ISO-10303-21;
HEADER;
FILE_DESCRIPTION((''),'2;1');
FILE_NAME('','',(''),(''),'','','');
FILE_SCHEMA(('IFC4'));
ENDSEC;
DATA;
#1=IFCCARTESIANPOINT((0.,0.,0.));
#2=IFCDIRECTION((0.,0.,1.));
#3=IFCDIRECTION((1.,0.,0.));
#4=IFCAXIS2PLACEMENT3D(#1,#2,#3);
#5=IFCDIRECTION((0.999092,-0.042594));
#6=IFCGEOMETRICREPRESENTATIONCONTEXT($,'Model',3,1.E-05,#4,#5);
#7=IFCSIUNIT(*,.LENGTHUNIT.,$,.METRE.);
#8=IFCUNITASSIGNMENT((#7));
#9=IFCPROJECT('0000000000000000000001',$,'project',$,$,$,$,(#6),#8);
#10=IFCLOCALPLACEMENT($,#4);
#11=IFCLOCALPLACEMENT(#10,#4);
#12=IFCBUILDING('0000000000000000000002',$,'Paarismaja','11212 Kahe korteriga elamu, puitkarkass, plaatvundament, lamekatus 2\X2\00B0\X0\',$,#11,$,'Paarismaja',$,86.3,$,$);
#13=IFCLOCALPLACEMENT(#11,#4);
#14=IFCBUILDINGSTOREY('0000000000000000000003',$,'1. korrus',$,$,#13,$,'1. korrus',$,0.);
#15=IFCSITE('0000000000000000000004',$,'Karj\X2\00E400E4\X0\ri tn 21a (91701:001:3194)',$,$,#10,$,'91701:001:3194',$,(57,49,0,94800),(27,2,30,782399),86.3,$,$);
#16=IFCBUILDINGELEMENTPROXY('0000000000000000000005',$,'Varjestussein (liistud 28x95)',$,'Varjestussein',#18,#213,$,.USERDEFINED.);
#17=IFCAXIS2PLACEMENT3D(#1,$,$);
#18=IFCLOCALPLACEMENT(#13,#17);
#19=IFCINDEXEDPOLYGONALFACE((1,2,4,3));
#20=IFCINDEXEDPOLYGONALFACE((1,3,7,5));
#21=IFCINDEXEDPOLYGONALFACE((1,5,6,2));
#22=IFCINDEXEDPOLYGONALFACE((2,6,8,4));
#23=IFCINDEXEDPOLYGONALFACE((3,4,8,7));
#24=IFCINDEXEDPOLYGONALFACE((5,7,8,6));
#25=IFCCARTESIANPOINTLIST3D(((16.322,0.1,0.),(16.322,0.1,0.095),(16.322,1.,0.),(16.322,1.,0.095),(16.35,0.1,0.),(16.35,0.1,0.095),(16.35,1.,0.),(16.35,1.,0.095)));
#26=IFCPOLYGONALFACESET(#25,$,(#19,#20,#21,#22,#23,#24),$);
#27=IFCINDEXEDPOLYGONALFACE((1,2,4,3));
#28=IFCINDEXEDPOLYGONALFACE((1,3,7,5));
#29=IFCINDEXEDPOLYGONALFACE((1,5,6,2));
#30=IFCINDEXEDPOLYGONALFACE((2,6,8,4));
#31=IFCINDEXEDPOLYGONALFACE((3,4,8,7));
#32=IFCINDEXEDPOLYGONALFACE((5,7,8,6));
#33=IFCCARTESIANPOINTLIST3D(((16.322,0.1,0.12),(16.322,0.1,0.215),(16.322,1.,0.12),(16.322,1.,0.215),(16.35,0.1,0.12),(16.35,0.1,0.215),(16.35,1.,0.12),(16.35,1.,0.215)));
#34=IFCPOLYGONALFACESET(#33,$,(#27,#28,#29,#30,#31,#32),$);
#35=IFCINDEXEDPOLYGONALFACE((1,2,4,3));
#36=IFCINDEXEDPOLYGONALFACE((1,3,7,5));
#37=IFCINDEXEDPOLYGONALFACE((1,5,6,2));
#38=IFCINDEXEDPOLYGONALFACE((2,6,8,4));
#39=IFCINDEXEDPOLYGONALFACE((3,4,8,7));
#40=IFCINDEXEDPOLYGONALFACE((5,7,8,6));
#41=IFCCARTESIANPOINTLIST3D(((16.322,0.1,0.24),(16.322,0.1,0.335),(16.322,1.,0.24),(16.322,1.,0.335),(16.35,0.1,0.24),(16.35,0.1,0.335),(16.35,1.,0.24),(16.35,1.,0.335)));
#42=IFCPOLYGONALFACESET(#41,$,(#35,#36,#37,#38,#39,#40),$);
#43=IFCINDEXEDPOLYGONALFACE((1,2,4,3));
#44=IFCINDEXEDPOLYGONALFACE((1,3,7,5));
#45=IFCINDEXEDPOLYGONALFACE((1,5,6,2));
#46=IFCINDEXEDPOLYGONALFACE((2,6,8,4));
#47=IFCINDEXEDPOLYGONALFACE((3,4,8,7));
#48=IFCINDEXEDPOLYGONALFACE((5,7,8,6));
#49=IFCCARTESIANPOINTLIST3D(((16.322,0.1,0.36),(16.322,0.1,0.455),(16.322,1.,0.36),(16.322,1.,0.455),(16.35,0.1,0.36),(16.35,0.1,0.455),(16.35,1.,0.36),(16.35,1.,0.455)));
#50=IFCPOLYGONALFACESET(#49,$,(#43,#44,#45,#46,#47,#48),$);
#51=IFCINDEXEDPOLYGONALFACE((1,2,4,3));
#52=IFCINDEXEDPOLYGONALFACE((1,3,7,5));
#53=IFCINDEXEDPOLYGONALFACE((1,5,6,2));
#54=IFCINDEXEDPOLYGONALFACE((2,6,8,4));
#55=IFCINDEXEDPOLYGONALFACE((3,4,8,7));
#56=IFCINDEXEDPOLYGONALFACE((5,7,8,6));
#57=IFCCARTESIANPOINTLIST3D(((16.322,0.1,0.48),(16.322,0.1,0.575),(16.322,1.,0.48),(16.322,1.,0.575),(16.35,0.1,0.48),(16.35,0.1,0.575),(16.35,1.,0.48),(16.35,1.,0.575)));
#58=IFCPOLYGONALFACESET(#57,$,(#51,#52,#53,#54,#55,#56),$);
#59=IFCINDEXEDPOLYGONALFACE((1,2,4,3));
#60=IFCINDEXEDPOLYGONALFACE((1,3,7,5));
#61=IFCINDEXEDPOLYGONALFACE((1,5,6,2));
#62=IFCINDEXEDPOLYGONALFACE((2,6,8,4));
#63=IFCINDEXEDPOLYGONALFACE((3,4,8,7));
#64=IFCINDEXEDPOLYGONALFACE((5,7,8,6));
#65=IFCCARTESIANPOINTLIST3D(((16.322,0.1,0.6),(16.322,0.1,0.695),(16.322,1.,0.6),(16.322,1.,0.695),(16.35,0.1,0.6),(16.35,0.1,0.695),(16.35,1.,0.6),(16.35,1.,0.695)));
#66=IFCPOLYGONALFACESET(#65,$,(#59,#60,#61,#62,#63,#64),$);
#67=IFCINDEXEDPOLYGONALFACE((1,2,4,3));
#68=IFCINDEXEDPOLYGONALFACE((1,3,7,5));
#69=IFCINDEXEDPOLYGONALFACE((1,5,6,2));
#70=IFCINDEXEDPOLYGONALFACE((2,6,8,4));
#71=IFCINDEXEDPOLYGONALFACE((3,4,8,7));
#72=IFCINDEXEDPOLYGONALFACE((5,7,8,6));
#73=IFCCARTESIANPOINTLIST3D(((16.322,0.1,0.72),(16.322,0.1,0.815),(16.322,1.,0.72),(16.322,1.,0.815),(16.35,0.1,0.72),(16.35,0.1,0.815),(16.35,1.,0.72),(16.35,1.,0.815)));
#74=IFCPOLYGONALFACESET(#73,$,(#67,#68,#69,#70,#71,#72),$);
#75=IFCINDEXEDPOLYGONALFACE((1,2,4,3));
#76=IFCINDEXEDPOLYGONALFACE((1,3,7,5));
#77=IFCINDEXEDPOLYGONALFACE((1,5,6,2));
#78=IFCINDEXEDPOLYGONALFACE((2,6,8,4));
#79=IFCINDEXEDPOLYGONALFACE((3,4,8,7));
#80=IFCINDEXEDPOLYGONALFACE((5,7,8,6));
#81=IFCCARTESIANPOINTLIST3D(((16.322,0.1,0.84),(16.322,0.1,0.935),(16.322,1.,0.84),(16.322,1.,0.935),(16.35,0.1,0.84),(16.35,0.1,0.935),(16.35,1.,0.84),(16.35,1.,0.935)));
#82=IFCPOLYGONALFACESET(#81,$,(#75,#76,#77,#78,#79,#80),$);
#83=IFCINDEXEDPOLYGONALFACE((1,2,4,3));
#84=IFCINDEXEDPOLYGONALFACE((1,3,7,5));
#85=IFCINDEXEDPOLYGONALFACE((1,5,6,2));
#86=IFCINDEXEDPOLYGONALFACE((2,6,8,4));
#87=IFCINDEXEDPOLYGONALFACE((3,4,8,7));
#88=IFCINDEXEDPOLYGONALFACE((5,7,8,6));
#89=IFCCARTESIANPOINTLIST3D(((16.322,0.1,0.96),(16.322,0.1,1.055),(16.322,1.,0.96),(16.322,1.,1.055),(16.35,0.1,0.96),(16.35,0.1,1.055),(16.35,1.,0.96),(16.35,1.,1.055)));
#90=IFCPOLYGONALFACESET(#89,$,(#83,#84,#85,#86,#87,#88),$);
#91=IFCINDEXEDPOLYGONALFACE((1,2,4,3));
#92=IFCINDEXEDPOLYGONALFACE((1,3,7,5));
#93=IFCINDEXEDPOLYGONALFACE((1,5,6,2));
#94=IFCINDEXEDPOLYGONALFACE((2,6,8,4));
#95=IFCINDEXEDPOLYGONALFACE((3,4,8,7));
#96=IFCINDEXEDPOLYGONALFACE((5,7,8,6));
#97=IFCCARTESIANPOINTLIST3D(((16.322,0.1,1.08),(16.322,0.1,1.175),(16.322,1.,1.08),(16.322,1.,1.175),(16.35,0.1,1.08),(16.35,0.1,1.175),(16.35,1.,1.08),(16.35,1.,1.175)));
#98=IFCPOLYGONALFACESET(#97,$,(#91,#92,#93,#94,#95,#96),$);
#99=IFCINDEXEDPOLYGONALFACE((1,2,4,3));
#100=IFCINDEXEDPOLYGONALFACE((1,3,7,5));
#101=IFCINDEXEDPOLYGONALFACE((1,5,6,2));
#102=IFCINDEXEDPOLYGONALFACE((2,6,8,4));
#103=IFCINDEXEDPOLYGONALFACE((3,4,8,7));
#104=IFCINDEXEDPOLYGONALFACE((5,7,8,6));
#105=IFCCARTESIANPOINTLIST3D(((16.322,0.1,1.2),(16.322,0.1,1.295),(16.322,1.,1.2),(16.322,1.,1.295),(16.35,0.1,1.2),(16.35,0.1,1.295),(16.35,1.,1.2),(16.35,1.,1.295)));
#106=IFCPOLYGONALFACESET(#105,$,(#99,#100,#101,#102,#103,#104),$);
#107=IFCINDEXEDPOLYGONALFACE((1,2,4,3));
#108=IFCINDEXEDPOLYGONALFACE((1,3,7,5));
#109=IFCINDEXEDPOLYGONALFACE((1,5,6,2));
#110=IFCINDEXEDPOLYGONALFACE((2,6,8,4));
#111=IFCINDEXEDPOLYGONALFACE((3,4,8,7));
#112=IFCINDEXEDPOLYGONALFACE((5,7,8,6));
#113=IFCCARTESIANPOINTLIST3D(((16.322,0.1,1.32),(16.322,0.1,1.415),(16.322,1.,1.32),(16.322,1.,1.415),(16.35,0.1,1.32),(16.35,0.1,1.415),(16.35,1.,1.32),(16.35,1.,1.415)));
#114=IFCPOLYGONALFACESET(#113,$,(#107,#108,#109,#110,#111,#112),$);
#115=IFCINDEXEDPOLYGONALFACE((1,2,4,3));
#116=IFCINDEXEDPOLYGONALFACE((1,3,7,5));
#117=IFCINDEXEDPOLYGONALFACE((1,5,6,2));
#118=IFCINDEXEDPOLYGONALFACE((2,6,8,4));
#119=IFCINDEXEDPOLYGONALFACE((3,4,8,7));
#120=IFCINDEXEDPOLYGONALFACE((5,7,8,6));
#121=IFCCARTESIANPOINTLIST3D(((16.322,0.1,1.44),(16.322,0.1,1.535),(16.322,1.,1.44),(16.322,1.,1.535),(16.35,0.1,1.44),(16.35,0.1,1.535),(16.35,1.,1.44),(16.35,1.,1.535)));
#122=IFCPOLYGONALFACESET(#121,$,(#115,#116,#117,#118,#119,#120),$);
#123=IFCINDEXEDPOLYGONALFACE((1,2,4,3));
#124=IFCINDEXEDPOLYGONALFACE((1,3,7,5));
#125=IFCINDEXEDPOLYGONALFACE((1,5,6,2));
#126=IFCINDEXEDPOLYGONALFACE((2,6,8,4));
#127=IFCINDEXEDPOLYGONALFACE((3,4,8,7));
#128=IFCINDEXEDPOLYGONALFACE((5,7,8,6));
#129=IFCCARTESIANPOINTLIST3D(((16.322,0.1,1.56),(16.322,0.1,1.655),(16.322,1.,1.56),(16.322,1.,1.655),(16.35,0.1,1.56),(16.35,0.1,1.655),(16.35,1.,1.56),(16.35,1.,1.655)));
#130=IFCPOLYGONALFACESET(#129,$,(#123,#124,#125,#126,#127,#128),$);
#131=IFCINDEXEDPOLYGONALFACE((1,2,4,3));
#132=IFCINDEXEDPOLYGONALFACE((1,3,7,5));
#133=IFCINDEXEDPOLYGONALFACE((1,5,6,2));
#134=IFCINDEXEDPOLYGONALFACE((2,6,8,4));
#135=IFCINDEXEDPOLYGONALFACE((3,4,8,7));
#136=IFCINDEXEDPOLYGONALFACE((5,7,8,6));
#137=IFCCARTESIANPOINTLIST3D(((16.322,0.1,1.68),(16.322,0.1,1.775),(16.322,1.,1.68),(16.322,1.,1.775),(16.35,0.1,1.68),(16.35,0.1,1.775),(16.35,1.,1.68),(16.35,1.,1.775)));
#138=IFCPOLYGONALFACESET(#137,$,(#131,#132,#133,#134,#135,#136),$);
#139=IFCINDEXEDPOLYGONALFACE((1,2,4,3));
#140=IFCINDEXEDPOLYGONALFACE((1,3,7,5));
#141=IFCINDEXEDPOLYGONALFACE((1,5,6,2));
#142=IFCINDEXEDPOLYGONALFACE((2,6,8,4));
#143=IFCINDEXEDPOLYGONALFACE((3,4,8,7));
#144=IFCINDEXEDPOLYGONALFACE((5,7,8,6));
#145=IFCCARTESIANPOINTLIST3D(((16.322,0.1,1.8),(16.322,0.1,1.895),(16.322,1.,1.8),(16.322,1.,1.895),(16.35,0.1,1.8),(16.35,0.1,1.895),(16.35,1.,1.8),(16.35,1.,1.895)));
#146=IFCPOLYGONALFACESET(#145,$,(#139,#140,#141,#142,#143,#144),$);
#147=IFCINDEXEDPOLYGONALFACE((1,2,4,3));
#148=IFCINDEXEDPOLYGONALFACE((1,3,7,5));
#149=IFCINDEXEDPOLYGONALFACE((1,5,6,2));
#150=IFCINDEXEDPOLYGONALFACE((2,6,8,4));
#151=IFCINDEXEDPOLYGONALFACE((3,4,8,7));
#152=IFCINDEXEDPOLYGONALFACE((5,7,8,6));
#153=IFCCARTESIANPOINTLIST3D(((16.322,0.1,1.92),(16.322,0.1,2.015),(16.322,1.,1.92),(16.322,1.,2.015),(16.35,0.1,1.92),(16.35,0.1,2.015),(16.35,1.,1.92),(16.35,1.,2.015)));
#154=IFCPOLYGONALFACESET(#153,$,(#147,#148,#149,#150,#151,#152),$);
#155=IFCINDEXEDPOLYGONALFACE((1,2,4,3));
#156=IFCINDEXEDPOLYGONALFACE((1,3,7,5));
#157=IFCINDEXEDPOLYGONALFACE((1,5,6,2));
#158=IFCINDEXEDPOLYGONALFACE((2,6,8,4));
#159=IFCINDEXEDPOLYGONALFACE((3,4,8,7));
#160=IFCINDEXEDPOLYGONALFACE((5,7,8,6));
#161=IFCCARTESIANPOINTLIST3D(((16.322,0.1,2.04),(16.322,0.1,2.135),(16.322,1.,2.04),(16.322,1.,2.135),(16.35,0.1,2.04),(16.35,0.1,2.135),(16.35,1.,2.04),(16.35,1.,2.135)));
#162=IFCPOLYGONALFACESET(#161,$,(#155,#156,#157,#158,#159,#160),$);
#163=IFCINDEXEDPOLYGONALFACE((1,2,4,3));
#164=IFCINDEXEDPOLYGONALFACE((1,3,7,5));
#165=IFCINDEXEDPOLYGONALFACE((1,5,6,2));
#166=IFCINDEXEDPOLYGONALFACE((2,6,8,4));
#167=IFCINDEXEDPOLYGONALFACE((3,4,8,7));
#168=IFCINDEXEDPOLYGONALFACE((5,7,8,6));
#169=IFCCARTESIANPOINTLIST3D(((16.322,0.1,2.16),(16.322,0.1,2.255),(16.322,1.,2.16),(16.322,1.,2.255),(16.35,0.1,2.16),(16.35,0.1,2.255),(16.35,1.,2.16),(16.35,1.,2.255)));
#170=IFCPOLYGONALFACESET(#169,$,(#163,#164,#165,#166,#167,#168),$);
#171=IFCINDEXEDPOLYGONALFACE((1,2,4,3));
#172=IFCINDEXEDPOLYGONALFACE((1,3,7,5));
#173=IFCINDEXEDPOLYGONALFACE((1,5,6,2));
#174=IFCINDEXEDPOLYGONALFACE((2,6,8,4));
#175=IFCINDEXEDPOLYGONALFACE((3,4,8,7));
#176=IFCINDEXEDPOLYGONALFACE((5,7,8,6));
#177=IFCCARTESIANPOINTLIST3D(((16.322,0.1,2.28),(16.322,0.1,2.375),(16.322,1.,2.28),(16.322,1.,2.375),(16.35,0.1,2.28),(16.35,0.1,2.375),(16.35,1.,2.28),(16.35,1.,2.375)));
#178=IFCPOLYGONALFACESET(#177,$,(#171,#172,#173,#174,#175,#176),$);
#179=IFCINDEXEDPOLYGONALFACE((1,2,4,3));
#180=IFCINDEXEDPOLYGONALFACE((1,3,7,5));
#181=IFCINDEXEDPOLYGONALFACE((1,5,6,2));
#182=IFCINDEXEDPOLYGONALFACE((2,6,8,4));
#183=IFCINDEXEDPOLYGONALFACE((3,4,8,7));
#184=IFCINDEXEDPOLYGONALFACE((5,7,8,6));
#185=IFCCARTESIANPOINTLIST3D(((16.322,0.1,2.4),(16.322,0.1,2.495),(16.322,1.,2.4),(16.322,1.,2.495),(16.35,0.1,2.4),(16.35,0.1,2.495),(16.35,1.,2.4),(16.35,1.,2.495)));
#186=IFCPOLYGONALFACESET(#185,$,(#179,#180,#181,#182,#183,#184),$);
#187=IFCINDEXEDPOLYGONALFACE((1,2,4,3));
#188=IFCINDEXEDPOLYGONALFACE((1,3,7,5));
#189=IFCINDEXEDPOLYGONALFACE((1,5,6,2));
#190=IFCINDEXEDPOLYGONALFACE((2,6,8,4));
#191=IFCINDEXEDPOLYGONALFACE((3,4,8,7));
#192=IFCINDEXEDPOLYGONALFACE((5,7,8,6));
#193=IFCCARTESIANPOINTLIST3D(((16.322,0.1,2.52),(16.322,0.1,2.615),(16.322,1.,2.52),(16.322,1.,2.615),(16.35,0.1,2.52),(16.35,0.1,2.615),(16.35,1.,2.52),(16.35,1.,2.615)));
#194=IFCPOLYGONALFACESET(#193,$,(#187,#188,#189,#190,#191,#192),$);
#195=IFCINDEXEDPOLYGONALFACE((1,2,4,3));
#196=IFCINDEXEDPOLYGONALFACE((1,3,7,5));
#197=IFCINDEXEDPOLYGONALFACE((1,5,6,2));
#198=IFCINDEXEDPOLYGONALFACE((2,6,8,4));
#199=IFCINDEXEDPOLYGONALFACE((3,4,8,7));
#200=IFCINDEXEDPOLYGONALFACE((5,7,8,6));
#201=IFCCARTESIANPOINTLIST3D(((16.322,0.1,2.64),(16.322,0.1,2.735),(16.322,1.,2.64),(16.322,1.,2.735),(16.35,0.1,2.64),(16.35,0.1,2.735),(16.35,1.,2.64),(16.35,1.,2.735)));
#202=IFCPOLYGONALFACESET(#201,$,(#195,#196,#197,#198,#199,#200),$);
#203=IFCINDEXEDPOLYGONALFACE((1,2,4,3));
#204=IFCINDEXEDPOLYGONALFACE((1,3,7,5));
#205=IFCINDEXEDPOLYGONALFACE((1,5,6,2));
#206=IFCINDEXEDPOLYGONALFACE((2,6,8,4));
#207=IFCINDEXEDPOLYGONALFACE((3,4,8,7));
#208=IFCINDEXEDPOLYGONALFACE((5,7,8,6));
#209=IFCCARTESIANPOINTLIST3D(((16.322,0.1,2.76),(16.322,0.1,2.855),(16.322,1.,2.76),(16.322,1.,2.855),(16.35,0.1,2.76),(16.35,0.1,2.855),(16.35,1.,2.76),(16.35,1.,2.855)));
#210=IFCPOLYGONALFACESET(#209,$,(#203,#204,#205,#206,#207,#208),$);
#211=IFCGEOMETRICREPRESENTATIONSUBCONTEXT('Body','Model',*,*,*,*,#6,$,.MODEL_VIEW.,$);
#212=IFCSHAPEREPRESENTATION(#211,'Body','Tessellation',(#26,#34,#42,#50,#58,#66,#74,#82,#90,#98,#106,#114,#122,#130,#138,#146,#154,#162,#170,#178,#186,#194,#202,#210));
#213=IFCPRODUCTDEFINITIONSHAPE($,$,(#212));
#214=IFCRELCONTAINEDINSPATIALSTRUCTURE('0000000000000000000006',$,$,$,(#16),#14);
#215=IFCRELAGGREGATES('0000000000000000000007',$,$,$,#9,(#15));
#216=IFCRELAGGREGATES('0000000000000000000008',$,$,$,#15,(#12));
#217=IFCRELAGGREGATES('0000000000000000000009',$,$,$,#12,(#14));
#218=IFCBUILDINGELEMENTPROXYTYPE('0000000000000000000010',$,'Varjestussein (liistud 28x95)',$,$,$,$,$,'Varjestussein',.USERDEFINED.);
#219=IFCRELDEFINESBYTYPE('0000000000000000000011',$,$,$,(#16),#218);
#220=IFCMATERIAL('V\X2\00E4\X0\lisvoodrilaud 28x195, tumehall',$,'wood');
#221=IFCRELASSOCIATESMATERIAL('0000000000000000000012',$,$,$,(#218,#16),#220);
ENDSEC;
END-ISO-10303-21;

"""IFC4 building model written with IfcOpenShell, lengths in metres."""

from ifc_helpers import new_model, si_unit, direction, frame, origin_with_axes, place, context, subcontext, project, spatial, indexed_curve, outline, extrude, material, type_object, element, save


model = new_model("IFC4")

# Units and contexts
model_context = context("Model", 3, precision=1e-05, world=origin_with_axes(), true_north=direction((0.999092, -0.042594)))
body_context = subcontext(model_context, "Body", "Model", "MODEL_VIEW")
ifc_project = project(units=[si_unit("LENGTHUNIT", "METRE")], contexts=[model_context])

# Site, building, storey
site_placement = place(None, origin_with_axes())
site = spatial("IfcSite", under=ifc_project, at=site_placement, Name="Karjääri tn 21a (91701:001:3194)", LongName="91701:001:3194", RefLatitude=(57, 49, 0, 94800), RefLongitude=(27, 2, 30, 782399), RefElevation=86.3)
building_placement = place(site_placement, origin_with_axes())
building = spatial("IfcBuilding", under=site, at=building_placement, Name="Paarismaja", Description="11212 Kahe korteriga elamu, puitkarkass, plaatvundament, lamekatus 2°", LongName="Paarismaja", ElevationOfRefHeight=86.3)
storey_placement = place(building_placement, origin_with_axes())
storey = spatial("IfcBuildingStorey", under=building, at=storey_placement, Name="1. korrus", LongName="1. korrus", Elevation=0.0)

# Building element proxy
ifc_material_1 = material(Name="Välisvoodrilaud 28x195, tumehall", Category="wood")
building_element_proxy_type_1 = type_object("IfcBuildingElementProxyType", Name="Varjestussein (liistud 28x95)", ElementType="Varjestussein", PredefinedType="USERDEFINED", material=ifc_material_1)
proxy_1_placement = place(storey_placement, origin_with_axes())
element("IfcBuildingElementProxy", 1, at=proxy_1_placement, inside=storey, type_object=building_element_proxy_type_1, material=ifc_material_1, Name="Varjestussein (liistud 28x95)", ObjectType="Varjestussein", PredefinedType="USERDEFINED", context=body_context, shape_type="SweptSolid", body=[
    extrude(outline(indexed_curve([(16.322, 0.1), (16.35, 0.1), (16.35, 1.0), (16.322, 1.0), (16.322, 0.1)], self_intersect=False)), origin_with_axes(), (0.0, 0.0, 1.0), 0.095),
    extrude(outline(indexed_curve([(16.322, 0.1), (16.35, 0.1), (16.35, 1.0), (16.322, 1.0), (16.322, 0.1)], self_intersect=False)), frame((0.0, 0.0, 0.12), z_axis=(0.0, 0.0, 1.0), x_axis=(1.0, 0.0, 0.0)), (0.0, 0.0, 1.0), 0.095),
    extrude(outline(indexed_curve([(16.322, 0.1), (16.35, 0.1), (16.35, 1.0), (16.322, 1.0), (16.322, 0.1)], self_intersect=False)), frame((0.0, 0.0, 0.24), z_axis=(0.0, 0.0, 1.0), x_axis=(1.0, 0.0, 0.0)), (0.0, 0.0, 1.0), 0.095),
    extrude(outline(indexed_curve([(16.322, 0.1), (16.35, 0.1), (16.35, 1.0), (16.322, 1.0), (16.322, 0.1)], self_intersect=False)), frame((0.0, 0.0, 0.36), z_axis=(0.0, 0.0, 1.0), x_axis=(1.0, 0.0, 0.0)), (0.0, 0.0, 1.0), 0.095),
    extrude(outline(indexed_curve([(16.322, 0.1), (16.35, 0.1), (16.35, 1.0), (16.322, 1.0), (16.322, 0.1)], self_intersect=False)), frame((0.0, 0.0, 0.48), z_axis=(0.0, 0.0, 1.0), x_axis=(1.0, 0.0, 0.0)), (0.0, 0.0, 1.0), 0.095),
    extrude(outline(indexed_curve([(16.322, 0.1), (16.35, 0.1), (16.35, 1.0), (16.322, 1.0), (16.322, 0.1)], self_intersect=False)), frame((0.0, 0.0, 0.6), z_axis=(0.0, 0.0, 1.0), x_axis=(1.0, 0.0, 0.0)), (0.0, 0.0, 1.0), 0.095),
    extrude(outline(indexed_curve([(16.322, 0.1), (16.35, 0.1), (16.35, 1.0), (16.322, 1.0), (16.322, 0.1)], self_intersect=False)), frame((0.0, 0.0, 0.72), z_axis=(0.0, 0.0, 1.0), x_axis=(1.0, 0.0, 0.0)), (0.0, 0.0, 1.0), 0.095),
    extrude(outline(indexed_curve([(16.322, 0.1), (16.35, 0.1), (16.35, 1.0), (16.322, 1.0), (16.322, 0.1)], self_intersect=False)), frame((0.0, 0.0, 0.84), z_axis=(0.0, 0.0, 1.0), x_axis=(1.0, 0.0, 0.0)), (0.0, 0.0, 1.0), 0.095),
    extrude(outline(indexed_curve([(16.322, 0.1), (16.35, 0.1), (16.35, 1.0), (16.322, 1.0), (16.322, 0.1)], self_intersect=False)), frame((0.0, 0.0, 0.96), z_axis=(0.0, 0.0, 1.0), x_axis=(1.0, 0.0, 0.0)), (0.0, 0.0, 1.0), 0.095),
    extrude(outline(indexed_curve([(16.322, 0.1), (16.35, 0.1), (16.35, 1.0), (16.322, 1.0), (16.322, 0.1)], self_intersect=False)), frame((0.0, 0.0, 1.08), z_axis=(0.0, 0.0, 1.0), x_axis=(1.0, 0.0, 0.0)), (0.0, 0.0, 1.0), 0.095),
    extrude(outline(indexed_curve([(16.322, 0.1), (16.35, 0.1), (16.35, 1.0), (16.322, 1.0), (16.322, 0.1)], self_intersect=False)), frame((0.0, 0.0, 1.2), z_axis=(0.0, 0.0, 1.0), x_axis=(1.0, 0.0, 0.0)), (0.0, 0.0, 1.0), 0.095),
    extrude(outline(indexed_curve([(16.322, 0.1), (16.35, 0.1), (16.35, 1.0), (16.322, 1.0), (16.322, 0.1)], self_intersect=False)), frame((0.0, 0.0, 1.32), z_axis=(0.0, 0.0, 1.0), x_axis=(1.0, 0.0, 0.0)), (0.0, 0.0, 1.0), 0.095),
    extrude(outline(indexed_curve([(16.322, 0.1), (16.35, 0.1), (16.35, 1.0), (16.322, 1.0), (16.322, 0.1)], self_intersect=False)), frame((0.0, 0.0, 1.44), z_axis=(0.0, 0.0, 1.0), x_axis=(1.0, 0.0, 0.0)), (0.0, 0.0, 1.0), 0.095),
    extrude(outline(indexed_curve([(16.322, 0.1), (16.35, 0.1), (16.35, 1.0), (16.322, 1.0), (16.322, 0.1)], self_intersect=False)), frame((0.0, 0.0, 1.56), z_axis=(0.0, 0.0, 1.0), x_axis=(1.0, 0.0, 0.0)), (0.0, 0.0, 1.0), 0.095),
    extrude(outline(indexed_curve([(16.322, 0.1), (16.35, 0.1), (16.35, 1.0), (16.322, 1.0), (16.322, 0.1)], self_intersect=False)), frame((0.0, 0.0, 1.68), z_axis=(0.0, 0.0, 1.0), x_axis=(1.0, 0.0, 0.0)), (0.0, 0.0, 1.0), 0.095),
    extrude(outline(indexed_curve([(16.322, 0.1), (16.35, 0.1), (16.35, 1.0), (16.322, 1.0), (16.322, 0.1)], self_intersect=False)), frame((0.0, 0.0, 1.8), z_axis=(0.0, 0.0, 1.0), x_axis=(1.0, 0.0, 0.0)), (0.0, 0.0, 1.0), 0.095),
    extrude(outline(indexed_curve([(16.322, 0.1), (16.35, 0.1), (16.35, 1.0), (16.322, 1.0), (16.322, 0.1)], self_intersect=False)), frame((0.0, 0.0, 1.92), z_axis=(0.0, 0.0, 1.0), x_axis=(1.0, 0.0, 0.0)), (0.0, 0.0, 1.0), 0.095),
    extrude(outline(indexed_curve([(16.322, 0.1), (16.35, 0.1), (16.35, 1.0), (16.322, 1.0), (16.322, 0.1)], self_intersect=False)), frame((0.0, 0.0, 2.04), z_axis=(0.0, 0.0, 1.0), x_axis=(1.0, 0.0, 0.0)), (0.0, 0.0, 1.0), 0.095),
    extrude(outline(indexed_curve([(16.322, 0.1), (16.35, 0.1), (16.35, 1.0), (16.322, 1.0), (16.322, 0.1)], self_intersect=False)), frame((0.0, 0.0, 2.16), z_axis=(0.0, 0.0, 1.0), x_axis=(1.0, 0.0, 0.0)), (0.0, 0.0, 1.0), 0.095),
    extrude(outline(indexed_curve([(16.322, 0.1), (16.35, 0.1), (16.35, 1.0), (16.322, 1.0), (16.322, 0.1)], self_intersect=False)), frame((0.0, 0.0, 2.28), z_axis=(0.0, 0.0, 1.0), x_axis=(1.0, 0.0, 0.0)), (0.0, 0.0, 1.0), 0.095),
    extrude(outline(indexed_curve([(16.322, 0.1), (16.35, 0.1), (16.35, 1.0), (16.322, 1.0), (16.322, 0.1)], self_intersect=False)), frame((0.0, 0.0, 2.4), z_axis=(0.0, 0.0, 1.0), x_axis=(1.0, 0.0, 0.0)), (0.0, 0.0, 1.0), 0.095),
    extrude(outline(indexed_curve([(16.322, 0.1), (16.35, 0.1), (16.35, 1.0), (16.322, 1.0), (16.322, 0.1)], self_intersect=False)), frame((0.0, 0.0, 2.52), z_axis=(0.0, 0.0, 1.0), x_axis=(1.0, 0.0, 0.0)), (0.0, 0.0, 1.0), 0.095),
    extrude(outline(indexed_curve([(16.322, 0.1), (16.35, 0.1), (16.35, 1.0), (16.322, 1.0), (16.322, 0.1)], self_intersect=False)), frame((0.0, 0.0, 2.64), z_axis=(0.0, 0.0, 1.0), x_axis=(1.0, 0.0, 0.0)), (0.0, 0.0, 1.0), 0.095),
    extrude(outline(indexed_curve([(16.322, 0.1), (16.35, 0.1), (16.35, 1.0), (16.322, 1.0), (16.322, 0.1)], self_intersect=False)), frame((0.0, 0.0, 2.76), z_axis=(0.0, 0.0, 1.0), x_axis=(1.0, 0.0, 0.0)), (0.0, 0.0, 1.0), 0.095),
])

save(model, "model.ifc")
